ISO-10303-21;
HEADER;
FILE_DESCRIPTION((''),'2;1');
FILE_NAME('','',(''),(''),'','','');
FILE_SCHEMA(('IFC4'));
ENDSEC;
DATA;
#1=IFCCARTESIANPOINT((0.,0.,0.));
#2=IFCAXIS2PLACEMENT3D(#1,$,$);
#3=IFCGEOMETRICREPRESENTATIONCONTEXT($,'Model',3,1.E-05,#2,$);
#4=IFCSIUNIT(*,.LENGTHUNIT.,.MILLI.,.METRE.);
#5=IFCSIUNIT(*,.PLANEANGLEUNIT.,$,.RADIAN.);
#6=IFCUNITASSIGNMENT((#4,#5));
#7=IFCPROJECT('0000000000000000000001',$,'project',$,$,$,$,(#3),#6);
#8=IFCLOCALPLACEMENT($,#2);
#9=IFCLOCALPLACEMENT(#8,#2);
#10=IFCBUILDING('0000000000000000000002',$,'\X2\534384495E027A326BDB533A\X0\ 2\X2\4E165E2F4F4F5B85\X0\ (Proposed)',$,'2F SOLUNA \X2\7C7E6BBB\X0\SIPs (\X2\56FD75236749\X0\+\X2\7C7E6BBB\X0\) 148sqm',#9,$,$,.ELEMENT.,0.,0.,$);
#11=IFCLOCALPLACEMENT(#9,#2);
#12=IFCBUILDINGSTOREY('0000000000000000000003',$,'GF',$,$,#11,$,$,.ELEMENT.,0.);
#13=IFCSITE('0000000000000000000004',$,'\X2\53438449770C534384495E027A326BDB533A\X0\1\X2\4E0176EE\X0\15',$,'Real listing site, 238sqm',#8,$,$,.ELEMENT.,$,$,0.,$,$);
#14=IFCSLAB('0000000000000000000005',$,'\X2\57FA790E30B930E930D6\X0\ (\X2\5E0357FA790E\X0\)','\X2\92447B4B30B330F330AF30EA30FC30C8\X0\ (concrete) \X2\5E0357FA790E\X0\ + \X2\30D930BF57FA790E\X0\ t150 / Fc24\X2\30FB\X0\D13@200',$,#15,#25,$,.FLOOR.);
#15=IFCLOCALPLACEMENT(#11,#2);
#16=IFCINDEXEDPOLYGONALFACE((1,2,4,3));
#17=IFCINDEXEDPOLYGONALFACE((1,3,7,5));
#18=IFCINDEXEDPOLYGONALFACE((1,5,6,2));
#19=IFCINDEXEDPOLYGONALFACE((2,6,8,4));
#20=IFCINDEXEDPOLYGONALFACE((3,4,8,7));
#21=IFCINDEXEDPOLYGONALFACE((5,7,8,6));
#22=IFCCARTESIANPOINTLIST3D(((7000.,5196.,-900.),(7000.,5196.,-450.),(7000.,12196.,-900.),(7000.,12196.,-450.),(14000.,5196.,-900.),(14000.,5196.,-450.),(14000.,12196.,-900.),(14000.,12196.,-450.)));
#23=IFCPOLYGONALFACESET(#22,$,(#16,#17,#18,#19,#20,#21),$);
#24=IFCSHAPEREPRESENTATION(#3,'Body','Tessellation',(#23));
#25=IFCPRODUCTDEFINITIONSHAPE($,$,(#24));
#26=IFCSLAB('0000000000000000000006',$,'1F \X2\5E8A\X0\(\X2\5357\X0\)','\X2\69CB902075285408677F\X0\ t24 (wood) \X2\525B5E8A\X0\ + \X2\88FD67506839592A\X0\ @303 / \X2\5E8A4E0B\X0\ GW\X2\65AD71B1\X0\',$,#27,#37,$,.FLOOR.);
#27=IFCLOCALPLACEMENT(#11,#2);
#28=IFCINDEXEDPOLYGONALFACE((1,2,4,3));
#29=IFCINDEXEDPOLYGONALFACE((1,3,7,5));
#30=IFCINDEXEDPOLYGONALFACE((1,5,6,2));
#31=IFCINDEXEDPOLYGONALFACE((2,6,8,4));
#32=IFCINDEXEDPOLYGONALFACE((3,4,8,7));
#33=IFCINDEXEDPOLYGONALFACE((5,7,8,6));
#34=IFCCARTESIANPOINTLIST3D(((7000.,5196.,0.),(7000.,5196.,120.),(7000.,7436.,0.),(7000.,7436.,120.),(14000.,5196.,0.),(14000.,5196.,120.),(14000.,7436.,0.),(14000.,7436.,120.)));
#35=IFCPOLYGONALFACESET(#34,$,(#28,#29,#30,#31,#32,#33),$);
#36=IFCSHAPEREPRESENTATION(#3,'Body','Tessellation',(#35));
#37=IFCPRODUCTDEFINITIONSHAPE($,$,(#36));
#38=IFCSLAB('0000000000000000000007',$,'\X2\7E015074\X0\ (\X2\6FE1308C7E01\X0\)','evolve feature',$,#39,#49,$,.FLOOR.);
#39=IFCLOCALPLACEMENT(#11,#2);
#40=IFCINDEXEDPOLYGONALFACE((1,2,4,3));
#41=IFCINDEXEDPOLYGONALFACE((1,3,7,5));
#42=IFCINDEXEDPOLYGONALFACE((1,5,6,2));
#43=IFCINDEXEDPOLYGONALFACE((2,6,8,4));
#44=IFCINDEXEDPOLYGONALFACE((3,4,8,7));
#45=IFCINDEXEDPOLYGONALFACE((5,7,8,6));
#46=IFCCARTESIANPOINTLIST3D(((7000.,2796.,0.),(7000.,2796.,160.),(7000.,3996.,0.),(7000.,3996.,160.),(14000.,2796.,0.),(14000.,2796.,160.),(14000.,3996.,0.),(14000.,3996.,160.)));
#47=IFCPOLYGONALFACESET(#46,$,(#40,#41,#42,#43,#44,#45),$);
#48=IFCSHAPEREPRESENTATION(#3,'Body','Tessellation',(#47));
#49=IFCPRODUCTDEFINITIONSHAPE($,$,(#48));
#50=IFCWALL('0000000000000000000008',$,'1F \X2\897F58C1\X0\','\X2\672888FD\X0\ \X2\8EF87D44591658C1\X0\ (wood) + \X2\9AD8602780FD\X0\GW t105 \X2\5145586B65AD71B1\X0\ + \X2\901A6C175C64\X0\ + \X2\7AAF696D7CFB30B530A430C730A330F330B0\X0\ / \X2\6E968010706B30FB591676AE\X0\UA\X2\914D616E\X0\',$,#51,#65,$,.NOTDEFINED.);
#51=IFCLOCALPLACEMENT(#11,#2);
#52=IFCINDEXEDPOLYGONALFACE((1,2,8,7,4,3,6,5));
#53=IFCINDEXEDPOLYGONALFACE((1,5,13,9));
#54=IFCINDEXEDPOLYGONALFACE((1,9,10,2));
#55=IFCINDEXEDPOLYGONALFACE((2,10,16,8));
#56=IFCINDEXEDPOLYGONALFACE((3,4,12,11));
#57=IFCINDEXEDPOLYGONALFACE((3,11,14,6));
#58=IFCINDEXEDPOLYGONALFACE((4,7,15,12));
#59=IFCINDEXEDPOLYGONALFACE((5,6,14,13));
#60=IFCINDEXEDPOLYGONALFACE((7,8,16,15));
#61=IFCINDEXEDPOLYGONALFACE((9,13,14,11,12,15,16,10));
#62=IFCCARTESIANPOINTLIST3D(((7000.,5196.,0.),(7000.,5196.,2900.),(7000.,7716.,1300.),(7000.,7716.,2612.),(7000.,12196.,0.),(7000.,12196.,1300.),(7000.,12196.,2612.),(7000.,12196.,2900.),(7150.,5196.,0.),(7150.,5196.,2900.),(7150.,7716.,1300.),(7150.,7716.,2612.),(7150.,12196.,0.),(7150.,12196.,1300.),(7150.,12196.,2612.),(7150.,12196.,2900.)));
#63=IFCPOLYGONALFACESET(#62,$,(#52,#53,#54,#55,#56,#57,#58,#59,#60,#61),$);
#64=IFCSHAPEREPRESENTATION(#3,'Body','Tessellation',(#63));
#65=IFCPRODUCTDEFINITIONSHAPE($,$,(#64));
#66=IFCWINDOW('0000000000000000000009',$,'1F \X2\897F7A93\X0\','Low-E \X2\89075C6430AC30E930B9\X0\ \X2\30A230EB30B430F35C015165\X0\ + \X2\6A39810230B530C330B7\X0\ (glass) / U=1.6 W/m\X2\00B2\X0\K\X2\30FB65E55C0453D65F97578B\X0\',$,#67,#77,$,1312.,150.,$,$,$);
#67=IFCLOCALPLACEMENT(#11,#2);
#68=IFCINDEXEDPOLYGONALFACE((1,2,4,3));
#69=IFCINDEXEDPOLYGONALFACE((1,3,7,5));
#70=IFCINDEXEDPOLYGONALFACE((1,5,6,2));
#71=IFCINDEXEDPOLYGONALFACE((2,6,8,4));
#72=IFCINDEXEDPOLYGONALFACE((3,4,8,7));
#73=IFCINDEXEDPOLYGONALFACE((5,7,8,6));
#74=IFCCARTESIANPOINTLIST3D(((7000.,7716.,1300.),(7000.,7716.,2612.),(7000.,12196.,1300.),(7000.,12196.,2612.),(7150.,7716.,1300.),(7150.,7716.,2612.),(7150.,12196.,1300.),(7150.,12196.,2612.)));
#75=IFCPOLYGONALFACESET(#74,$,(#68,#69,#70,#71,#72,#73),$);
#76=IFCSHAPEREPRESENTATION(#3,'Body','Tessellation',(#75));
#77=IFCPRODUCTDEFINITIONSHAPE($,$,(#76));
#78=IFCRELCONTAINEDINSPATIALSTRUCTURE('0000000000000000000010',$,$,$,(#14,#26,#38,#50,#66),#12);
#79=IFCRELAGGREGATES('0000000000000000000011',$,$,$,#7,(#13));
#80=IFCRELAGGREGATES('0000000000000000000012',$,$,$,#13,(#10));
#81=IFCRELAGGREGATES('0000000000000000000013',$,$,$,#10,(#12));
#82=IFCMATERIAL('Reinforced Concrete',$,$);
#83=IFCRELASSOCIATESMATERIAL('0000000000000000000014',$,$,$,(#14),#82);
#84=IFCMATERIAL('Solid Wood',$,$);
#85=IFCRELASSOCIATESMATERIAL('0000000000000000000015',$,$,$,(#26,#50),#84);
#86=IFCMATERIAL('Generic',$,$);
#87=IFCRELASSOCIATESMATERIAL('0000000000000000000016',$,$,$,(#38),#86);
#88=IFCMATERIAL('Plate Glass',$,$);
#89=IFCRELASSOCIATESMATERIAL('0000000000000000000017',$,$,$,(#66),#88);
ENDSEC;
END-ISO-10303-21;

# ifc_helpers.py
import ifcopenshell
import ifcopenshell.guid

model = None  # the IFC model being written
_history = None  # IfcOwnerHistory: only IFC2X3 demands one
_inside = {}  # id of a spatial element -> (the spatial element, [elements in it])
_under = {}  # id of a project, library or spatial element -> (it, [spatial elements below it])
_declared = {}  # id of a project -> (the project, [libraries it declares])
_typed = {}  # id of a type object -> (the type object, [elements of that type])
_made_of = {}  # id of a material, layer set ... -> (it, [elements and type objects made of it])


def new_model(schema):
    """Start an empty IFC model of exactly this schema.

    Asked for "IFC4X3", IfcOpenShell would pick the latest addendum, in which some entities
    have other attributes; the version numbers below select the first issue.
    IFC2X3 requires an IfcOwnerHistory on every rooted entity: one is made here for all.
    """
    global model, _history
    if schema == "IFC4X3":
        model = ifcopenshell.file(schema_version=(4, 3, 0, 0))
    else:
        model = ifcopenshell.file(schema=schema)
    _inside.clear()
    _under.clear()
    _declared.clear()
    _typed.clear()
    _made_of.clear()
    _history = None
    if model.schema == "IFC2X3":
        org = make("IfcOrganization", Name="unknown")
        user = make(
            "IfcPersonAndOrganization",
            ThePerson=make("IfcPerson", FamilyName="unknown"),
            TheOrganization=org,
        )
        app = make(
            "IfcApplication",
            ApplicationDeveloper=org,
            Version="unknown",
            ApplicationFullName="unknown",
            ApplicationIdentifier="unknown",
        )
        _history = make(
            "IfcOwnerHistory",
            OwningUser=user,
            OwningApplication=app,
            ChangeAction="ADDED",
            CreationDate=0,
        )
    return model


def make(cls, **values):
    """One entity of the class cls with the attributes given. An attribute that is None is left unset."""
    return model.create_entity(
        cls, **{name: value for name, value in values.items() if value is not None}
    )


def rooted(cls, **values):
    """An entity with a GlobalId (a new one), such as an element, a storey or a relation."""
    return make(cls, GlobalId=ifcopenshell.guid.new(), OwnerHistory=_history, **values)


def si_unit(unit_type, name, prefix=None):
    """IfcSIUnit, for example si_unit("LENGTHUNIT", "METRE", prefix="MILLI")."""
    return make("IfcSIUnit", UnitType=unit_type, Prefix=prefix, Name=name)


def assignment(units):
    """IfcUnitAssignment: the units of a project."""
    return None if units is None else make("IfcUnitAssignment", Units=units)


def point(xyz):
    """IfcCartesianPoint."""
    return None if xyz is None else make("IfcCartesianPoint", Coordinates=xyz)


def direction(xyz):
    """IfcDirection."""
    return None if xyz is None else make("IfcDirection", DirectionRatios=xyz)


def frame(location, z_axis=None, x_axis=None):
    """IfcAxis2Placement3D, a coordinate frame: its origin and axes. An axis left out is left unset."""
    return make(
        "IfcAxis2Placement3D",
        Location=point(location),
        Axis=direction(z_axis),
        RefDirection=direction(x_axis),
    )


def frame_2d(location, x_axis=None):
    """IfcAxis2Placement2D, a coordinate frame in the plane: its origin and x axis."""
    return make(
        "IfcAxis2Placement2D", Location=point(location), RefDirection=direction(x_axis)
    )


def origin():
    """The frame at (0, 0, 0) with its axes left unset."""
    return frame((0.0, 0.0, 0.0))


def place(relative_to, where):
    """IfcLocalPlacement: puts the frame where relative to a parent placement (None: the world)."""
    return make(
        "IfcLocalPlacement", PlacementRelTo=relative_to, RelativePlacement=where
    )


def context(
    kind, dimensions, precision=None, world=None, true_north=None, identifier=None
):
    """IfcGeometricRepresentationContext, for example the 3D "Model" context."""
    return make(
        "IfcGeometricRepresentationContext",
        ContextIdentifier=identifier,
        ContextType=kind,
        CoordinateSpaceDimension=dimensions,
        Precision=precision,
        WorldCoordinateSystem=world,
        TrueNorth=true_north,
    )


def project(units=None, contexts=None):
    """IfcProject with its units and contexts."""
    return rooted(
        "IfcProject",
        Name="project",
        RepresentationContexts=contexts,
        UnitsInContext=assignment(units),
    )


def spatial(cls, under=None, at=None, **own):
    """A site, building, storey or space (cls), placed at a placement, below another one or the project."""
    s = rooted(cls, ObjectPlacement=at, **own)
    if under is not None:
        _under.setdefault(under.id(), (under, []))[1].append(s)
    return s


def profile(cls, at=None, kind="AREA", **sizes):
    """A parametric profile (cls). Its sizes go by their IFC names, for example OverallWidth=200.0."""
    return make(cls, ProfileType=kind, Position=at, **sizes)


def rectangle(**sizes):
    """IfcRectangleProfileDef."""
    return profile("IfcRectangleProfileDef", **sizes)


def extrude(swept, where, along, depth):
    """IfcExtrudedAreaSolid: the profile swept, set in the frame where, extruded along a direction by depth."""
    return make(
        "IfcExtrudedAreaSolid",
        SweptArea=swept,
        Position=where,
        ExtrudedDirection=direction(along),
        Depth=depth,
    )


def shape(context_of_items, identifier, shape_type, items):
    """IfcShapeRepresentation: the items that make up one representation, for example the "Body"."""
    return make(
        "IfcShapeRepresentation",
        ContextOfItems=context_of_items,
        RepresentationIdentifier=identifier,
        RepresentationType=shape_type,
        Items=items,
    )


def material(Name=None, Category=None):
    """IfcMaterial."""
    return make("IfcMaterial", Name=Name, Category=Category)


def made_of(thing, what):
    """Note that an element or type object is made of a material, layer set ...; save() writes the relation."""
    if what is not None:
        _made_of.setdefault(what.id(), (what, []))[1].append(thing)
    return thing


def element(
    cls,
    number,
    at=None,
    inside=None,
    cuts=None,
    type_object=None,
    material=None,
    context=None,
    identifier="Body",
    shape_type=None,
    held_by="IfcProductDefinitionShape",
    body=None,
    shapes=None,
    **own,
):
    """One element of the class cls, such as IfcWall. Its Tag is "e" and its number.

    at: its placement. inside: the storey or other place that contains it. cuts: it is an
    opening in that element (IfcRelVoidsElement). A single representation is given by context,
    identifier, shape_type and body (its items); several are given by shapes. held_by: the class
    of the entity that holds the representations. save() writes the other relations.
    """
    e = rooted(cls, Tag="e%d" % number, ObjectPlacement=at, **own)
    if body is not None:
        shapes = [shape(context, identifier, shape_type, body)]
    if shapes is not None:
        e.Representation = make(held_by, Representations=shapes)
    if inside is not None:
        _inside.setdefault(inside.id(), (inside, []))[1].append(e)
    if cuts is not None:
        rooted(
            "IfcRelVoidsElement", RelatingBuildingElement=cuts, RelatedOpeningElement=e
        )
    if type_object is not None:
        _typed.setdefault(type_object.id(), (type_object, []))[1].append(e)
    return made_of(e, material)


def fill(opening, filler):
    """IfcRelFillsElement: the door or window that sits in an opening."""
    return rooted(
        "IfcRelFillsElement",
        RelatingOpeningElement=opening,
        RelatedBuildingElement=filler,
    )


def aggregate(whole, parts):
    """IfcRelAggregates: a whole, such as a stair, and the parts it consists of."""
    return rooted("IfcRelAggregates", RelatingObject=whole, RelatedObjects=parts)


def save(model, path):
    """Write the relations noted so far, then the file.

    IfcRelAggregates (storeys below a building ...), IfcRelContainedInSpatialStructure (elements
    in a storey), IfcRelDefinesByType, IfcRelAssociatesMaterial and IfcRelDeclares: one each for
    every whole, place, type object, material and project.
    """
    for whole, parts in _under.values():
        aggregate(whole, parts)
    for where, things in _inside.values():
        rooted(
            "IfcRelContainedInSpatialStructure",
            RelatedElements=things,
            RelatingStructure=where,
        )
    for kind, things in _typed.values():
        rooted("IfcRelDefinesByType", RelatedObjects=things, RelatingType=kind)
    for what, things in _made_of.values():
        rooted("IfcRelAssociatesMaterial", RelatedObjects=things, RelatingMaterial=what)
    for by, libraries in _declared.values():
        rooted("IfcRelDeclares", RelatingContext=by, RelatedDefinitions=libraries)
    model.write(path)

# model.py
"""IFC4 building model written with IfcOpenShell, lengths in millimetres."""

from ifc_helpers import new_model, si_unit, frame, frame_2d, origin, place, context, project, spatial, rectangle, extrude, material, element, fill, save


model = new_model("IFC4")

# Units and contexts
model_context = context("Model", 3, precision=1e-05, world=origin())
ifc_project = project(units=[si_unit("LENGTHUNIT", "METRE", prefix="MILLI"), si_unit("PLANEANGLEUNIT", "RADIAN")], contexts=[model_context])

# Site, building, storey
site_placement = place(None, origin())
site = spatial("IfcSite", under=ifc_project, at=site_placement, Name="千葉県千葉市稲毛区1丁目15", ObjectType="Real listing site, 238sqm", CompositionType="ELEMENT", RefElevation=0.0)
building_placement = place(site_placement, origin())
building = spatial("IfcBuilding", under=site, at=building_placement, Name="千葉市稲毛区 2世帯住宅 (Proposed)", ObjectType="2F SOLUNA 籾殻SIPs (国産杉+籾殻) 148sqm", CompositionType="ELEMENT", ElevationOfRefHeight=0.0, ElevationOfTerrain=0.0)
storey_placement = place(building_placement, origin())
storey = spatial("IfcBuildingStorey", under=building, at=storey_placement, Name="GF", CompositionType="ELEMENT", Elevation=0.0)

# Slabs
ifc_material_1 = material(Name="Reinforced Concrete")
slab_1_placement = place(storey_placement, frame((3500.0, 2598.0, -450.0)))
element("IfcSlab", 1, at=slab_1_placement, inside=storey, material=ifc_material_1, Name="基礎スラブ (布基礎)", Description="鉄筋コンクリート (concrete) 布基礎 + ベタ基礎 t150 / Fc24・D13@200", PredefinedType="FLOOR", context=model_context, shape_type="SweptSolid", body=[
    extrude(rectangle(XDim=7000.0, YDim=7000.0, at=frame_2d((3500.0, 3500.0))), frame((3500.0, 2598.0, -450.0)), (0.0, 0.0, 1.0), 450.0),
])
ifc_material_2 = material(Name="Solid Wood")
slab_2_placement = place(storey_placement, frame((3500.0, 2598.0, 0.0)))
element("IfcSlab", 2, at=slab_2_placement, inside=storey, material=ifc_material_2, Name="1F 床(南)", Description="構造用合板 t24 (wood) 剛床 + 製材根太 @303 / 床下 GW断熱", PredefinedType="FLOOR", context=model_context, shape_type="SweptSolid", body=[
    extrude(rectangle(XDim=7000.0, YDim=2240.0, at=frame_2d((3500.0, 1120.0))), frame((3500.0, 2598.0, 0.0)), (0.0, 0.0, 1.0), 120.0),
])
ifc_material_3 = material(Name="Generic")
slab_3_placement = place(storey_placement, frame((3500.0, 1398.0, 0.0)))
element("IfcSlab", 3, at=slab_3_placement, inside=storey, material=ifc_material_3, Name="縁側 (濡れ縁)", Description="evolve feature", PredefinedType="FLOOR", context=model_context, shape_type="SweptSolid", body=[
    extrude(rectangle(XDim=7000.0, YDim=1200.0, at=frame_2d((3500.0, 600.0))), frame((3500.0, 1398.0, 0.0)), (0.0, 0.0, 1.0), 160.0),
])

# Shared definitions
ifc_material_4 = material(Name="Plate Glass")

# Wall, opening, window
wall_1_placement = place(storey_placement, frame((3500.0, 2598.0, 0.0)))
wall_1 = element("IfcWall", 4, at=wall_1_placement, inside=storey, material=ifc_material_2, Name="1F 西壁", Description="木製 軸組外壁 (wood) + 高性能GW t105 充填断熱 + 通気層 + 窯業系サイディング / 準耐火・外皮UA配慮", PredefinedType="NOTDEFINED", context=model_context, shape_type="SweptSolid", body=[
    extrude(rectangle(XDim=150.0, YDim=7000.0, at=frame_2d((75.0, 3500.0))), frame((3500.0, 2598.0, 0.0)), (0.0, 0.0, 1.0), 2900.0),
])
opening_1_placement = place(storey_placement, frame((3500.0, 3858.0, 650.0)))
opening_1 = element("IfcOpeningElement", 5, at=opening_1_placement, cuts=wall_1, PredefinedType="NOTDEFINED", context=model_context, shape_type="SweptSolid", body=[
    extrude(rectangle(XDim=150.0, YDim=4480.0, at=frame_2d((75.0, 2240.0))), frame((3500.0, 3858.0, 650.0)), (0.0, 0.0, 1.0), 1312.0),
])
window_1_placement = place(storey_placement, frame((3500.0, 3858.0, 650.0)))
window_1 = element("IfcWindow", 6, at=window_1_placement, inside=storey, material=ifc_material_4, Name="1F 西窓", Description="Low-E 複層ガラス アルゴン封入 + 樹脂サッシ (glass) / U=1.6 W/m²K・日射取得型", OverallHeight=1312.0, OverallWidth=150.0, context=model_context, shape_type="SweptSolid", body=[
    extrude(rectangle(XDim=150.0, YDim=4480.0, at=frame_2d((75.0, 2240.0))), frame((3500.0, 3858.0, 650.0)), (0.0, 0.0, 1.0), 1312.0),
])
fill(opening_1, window_1)

save(model, "model.ifc")
